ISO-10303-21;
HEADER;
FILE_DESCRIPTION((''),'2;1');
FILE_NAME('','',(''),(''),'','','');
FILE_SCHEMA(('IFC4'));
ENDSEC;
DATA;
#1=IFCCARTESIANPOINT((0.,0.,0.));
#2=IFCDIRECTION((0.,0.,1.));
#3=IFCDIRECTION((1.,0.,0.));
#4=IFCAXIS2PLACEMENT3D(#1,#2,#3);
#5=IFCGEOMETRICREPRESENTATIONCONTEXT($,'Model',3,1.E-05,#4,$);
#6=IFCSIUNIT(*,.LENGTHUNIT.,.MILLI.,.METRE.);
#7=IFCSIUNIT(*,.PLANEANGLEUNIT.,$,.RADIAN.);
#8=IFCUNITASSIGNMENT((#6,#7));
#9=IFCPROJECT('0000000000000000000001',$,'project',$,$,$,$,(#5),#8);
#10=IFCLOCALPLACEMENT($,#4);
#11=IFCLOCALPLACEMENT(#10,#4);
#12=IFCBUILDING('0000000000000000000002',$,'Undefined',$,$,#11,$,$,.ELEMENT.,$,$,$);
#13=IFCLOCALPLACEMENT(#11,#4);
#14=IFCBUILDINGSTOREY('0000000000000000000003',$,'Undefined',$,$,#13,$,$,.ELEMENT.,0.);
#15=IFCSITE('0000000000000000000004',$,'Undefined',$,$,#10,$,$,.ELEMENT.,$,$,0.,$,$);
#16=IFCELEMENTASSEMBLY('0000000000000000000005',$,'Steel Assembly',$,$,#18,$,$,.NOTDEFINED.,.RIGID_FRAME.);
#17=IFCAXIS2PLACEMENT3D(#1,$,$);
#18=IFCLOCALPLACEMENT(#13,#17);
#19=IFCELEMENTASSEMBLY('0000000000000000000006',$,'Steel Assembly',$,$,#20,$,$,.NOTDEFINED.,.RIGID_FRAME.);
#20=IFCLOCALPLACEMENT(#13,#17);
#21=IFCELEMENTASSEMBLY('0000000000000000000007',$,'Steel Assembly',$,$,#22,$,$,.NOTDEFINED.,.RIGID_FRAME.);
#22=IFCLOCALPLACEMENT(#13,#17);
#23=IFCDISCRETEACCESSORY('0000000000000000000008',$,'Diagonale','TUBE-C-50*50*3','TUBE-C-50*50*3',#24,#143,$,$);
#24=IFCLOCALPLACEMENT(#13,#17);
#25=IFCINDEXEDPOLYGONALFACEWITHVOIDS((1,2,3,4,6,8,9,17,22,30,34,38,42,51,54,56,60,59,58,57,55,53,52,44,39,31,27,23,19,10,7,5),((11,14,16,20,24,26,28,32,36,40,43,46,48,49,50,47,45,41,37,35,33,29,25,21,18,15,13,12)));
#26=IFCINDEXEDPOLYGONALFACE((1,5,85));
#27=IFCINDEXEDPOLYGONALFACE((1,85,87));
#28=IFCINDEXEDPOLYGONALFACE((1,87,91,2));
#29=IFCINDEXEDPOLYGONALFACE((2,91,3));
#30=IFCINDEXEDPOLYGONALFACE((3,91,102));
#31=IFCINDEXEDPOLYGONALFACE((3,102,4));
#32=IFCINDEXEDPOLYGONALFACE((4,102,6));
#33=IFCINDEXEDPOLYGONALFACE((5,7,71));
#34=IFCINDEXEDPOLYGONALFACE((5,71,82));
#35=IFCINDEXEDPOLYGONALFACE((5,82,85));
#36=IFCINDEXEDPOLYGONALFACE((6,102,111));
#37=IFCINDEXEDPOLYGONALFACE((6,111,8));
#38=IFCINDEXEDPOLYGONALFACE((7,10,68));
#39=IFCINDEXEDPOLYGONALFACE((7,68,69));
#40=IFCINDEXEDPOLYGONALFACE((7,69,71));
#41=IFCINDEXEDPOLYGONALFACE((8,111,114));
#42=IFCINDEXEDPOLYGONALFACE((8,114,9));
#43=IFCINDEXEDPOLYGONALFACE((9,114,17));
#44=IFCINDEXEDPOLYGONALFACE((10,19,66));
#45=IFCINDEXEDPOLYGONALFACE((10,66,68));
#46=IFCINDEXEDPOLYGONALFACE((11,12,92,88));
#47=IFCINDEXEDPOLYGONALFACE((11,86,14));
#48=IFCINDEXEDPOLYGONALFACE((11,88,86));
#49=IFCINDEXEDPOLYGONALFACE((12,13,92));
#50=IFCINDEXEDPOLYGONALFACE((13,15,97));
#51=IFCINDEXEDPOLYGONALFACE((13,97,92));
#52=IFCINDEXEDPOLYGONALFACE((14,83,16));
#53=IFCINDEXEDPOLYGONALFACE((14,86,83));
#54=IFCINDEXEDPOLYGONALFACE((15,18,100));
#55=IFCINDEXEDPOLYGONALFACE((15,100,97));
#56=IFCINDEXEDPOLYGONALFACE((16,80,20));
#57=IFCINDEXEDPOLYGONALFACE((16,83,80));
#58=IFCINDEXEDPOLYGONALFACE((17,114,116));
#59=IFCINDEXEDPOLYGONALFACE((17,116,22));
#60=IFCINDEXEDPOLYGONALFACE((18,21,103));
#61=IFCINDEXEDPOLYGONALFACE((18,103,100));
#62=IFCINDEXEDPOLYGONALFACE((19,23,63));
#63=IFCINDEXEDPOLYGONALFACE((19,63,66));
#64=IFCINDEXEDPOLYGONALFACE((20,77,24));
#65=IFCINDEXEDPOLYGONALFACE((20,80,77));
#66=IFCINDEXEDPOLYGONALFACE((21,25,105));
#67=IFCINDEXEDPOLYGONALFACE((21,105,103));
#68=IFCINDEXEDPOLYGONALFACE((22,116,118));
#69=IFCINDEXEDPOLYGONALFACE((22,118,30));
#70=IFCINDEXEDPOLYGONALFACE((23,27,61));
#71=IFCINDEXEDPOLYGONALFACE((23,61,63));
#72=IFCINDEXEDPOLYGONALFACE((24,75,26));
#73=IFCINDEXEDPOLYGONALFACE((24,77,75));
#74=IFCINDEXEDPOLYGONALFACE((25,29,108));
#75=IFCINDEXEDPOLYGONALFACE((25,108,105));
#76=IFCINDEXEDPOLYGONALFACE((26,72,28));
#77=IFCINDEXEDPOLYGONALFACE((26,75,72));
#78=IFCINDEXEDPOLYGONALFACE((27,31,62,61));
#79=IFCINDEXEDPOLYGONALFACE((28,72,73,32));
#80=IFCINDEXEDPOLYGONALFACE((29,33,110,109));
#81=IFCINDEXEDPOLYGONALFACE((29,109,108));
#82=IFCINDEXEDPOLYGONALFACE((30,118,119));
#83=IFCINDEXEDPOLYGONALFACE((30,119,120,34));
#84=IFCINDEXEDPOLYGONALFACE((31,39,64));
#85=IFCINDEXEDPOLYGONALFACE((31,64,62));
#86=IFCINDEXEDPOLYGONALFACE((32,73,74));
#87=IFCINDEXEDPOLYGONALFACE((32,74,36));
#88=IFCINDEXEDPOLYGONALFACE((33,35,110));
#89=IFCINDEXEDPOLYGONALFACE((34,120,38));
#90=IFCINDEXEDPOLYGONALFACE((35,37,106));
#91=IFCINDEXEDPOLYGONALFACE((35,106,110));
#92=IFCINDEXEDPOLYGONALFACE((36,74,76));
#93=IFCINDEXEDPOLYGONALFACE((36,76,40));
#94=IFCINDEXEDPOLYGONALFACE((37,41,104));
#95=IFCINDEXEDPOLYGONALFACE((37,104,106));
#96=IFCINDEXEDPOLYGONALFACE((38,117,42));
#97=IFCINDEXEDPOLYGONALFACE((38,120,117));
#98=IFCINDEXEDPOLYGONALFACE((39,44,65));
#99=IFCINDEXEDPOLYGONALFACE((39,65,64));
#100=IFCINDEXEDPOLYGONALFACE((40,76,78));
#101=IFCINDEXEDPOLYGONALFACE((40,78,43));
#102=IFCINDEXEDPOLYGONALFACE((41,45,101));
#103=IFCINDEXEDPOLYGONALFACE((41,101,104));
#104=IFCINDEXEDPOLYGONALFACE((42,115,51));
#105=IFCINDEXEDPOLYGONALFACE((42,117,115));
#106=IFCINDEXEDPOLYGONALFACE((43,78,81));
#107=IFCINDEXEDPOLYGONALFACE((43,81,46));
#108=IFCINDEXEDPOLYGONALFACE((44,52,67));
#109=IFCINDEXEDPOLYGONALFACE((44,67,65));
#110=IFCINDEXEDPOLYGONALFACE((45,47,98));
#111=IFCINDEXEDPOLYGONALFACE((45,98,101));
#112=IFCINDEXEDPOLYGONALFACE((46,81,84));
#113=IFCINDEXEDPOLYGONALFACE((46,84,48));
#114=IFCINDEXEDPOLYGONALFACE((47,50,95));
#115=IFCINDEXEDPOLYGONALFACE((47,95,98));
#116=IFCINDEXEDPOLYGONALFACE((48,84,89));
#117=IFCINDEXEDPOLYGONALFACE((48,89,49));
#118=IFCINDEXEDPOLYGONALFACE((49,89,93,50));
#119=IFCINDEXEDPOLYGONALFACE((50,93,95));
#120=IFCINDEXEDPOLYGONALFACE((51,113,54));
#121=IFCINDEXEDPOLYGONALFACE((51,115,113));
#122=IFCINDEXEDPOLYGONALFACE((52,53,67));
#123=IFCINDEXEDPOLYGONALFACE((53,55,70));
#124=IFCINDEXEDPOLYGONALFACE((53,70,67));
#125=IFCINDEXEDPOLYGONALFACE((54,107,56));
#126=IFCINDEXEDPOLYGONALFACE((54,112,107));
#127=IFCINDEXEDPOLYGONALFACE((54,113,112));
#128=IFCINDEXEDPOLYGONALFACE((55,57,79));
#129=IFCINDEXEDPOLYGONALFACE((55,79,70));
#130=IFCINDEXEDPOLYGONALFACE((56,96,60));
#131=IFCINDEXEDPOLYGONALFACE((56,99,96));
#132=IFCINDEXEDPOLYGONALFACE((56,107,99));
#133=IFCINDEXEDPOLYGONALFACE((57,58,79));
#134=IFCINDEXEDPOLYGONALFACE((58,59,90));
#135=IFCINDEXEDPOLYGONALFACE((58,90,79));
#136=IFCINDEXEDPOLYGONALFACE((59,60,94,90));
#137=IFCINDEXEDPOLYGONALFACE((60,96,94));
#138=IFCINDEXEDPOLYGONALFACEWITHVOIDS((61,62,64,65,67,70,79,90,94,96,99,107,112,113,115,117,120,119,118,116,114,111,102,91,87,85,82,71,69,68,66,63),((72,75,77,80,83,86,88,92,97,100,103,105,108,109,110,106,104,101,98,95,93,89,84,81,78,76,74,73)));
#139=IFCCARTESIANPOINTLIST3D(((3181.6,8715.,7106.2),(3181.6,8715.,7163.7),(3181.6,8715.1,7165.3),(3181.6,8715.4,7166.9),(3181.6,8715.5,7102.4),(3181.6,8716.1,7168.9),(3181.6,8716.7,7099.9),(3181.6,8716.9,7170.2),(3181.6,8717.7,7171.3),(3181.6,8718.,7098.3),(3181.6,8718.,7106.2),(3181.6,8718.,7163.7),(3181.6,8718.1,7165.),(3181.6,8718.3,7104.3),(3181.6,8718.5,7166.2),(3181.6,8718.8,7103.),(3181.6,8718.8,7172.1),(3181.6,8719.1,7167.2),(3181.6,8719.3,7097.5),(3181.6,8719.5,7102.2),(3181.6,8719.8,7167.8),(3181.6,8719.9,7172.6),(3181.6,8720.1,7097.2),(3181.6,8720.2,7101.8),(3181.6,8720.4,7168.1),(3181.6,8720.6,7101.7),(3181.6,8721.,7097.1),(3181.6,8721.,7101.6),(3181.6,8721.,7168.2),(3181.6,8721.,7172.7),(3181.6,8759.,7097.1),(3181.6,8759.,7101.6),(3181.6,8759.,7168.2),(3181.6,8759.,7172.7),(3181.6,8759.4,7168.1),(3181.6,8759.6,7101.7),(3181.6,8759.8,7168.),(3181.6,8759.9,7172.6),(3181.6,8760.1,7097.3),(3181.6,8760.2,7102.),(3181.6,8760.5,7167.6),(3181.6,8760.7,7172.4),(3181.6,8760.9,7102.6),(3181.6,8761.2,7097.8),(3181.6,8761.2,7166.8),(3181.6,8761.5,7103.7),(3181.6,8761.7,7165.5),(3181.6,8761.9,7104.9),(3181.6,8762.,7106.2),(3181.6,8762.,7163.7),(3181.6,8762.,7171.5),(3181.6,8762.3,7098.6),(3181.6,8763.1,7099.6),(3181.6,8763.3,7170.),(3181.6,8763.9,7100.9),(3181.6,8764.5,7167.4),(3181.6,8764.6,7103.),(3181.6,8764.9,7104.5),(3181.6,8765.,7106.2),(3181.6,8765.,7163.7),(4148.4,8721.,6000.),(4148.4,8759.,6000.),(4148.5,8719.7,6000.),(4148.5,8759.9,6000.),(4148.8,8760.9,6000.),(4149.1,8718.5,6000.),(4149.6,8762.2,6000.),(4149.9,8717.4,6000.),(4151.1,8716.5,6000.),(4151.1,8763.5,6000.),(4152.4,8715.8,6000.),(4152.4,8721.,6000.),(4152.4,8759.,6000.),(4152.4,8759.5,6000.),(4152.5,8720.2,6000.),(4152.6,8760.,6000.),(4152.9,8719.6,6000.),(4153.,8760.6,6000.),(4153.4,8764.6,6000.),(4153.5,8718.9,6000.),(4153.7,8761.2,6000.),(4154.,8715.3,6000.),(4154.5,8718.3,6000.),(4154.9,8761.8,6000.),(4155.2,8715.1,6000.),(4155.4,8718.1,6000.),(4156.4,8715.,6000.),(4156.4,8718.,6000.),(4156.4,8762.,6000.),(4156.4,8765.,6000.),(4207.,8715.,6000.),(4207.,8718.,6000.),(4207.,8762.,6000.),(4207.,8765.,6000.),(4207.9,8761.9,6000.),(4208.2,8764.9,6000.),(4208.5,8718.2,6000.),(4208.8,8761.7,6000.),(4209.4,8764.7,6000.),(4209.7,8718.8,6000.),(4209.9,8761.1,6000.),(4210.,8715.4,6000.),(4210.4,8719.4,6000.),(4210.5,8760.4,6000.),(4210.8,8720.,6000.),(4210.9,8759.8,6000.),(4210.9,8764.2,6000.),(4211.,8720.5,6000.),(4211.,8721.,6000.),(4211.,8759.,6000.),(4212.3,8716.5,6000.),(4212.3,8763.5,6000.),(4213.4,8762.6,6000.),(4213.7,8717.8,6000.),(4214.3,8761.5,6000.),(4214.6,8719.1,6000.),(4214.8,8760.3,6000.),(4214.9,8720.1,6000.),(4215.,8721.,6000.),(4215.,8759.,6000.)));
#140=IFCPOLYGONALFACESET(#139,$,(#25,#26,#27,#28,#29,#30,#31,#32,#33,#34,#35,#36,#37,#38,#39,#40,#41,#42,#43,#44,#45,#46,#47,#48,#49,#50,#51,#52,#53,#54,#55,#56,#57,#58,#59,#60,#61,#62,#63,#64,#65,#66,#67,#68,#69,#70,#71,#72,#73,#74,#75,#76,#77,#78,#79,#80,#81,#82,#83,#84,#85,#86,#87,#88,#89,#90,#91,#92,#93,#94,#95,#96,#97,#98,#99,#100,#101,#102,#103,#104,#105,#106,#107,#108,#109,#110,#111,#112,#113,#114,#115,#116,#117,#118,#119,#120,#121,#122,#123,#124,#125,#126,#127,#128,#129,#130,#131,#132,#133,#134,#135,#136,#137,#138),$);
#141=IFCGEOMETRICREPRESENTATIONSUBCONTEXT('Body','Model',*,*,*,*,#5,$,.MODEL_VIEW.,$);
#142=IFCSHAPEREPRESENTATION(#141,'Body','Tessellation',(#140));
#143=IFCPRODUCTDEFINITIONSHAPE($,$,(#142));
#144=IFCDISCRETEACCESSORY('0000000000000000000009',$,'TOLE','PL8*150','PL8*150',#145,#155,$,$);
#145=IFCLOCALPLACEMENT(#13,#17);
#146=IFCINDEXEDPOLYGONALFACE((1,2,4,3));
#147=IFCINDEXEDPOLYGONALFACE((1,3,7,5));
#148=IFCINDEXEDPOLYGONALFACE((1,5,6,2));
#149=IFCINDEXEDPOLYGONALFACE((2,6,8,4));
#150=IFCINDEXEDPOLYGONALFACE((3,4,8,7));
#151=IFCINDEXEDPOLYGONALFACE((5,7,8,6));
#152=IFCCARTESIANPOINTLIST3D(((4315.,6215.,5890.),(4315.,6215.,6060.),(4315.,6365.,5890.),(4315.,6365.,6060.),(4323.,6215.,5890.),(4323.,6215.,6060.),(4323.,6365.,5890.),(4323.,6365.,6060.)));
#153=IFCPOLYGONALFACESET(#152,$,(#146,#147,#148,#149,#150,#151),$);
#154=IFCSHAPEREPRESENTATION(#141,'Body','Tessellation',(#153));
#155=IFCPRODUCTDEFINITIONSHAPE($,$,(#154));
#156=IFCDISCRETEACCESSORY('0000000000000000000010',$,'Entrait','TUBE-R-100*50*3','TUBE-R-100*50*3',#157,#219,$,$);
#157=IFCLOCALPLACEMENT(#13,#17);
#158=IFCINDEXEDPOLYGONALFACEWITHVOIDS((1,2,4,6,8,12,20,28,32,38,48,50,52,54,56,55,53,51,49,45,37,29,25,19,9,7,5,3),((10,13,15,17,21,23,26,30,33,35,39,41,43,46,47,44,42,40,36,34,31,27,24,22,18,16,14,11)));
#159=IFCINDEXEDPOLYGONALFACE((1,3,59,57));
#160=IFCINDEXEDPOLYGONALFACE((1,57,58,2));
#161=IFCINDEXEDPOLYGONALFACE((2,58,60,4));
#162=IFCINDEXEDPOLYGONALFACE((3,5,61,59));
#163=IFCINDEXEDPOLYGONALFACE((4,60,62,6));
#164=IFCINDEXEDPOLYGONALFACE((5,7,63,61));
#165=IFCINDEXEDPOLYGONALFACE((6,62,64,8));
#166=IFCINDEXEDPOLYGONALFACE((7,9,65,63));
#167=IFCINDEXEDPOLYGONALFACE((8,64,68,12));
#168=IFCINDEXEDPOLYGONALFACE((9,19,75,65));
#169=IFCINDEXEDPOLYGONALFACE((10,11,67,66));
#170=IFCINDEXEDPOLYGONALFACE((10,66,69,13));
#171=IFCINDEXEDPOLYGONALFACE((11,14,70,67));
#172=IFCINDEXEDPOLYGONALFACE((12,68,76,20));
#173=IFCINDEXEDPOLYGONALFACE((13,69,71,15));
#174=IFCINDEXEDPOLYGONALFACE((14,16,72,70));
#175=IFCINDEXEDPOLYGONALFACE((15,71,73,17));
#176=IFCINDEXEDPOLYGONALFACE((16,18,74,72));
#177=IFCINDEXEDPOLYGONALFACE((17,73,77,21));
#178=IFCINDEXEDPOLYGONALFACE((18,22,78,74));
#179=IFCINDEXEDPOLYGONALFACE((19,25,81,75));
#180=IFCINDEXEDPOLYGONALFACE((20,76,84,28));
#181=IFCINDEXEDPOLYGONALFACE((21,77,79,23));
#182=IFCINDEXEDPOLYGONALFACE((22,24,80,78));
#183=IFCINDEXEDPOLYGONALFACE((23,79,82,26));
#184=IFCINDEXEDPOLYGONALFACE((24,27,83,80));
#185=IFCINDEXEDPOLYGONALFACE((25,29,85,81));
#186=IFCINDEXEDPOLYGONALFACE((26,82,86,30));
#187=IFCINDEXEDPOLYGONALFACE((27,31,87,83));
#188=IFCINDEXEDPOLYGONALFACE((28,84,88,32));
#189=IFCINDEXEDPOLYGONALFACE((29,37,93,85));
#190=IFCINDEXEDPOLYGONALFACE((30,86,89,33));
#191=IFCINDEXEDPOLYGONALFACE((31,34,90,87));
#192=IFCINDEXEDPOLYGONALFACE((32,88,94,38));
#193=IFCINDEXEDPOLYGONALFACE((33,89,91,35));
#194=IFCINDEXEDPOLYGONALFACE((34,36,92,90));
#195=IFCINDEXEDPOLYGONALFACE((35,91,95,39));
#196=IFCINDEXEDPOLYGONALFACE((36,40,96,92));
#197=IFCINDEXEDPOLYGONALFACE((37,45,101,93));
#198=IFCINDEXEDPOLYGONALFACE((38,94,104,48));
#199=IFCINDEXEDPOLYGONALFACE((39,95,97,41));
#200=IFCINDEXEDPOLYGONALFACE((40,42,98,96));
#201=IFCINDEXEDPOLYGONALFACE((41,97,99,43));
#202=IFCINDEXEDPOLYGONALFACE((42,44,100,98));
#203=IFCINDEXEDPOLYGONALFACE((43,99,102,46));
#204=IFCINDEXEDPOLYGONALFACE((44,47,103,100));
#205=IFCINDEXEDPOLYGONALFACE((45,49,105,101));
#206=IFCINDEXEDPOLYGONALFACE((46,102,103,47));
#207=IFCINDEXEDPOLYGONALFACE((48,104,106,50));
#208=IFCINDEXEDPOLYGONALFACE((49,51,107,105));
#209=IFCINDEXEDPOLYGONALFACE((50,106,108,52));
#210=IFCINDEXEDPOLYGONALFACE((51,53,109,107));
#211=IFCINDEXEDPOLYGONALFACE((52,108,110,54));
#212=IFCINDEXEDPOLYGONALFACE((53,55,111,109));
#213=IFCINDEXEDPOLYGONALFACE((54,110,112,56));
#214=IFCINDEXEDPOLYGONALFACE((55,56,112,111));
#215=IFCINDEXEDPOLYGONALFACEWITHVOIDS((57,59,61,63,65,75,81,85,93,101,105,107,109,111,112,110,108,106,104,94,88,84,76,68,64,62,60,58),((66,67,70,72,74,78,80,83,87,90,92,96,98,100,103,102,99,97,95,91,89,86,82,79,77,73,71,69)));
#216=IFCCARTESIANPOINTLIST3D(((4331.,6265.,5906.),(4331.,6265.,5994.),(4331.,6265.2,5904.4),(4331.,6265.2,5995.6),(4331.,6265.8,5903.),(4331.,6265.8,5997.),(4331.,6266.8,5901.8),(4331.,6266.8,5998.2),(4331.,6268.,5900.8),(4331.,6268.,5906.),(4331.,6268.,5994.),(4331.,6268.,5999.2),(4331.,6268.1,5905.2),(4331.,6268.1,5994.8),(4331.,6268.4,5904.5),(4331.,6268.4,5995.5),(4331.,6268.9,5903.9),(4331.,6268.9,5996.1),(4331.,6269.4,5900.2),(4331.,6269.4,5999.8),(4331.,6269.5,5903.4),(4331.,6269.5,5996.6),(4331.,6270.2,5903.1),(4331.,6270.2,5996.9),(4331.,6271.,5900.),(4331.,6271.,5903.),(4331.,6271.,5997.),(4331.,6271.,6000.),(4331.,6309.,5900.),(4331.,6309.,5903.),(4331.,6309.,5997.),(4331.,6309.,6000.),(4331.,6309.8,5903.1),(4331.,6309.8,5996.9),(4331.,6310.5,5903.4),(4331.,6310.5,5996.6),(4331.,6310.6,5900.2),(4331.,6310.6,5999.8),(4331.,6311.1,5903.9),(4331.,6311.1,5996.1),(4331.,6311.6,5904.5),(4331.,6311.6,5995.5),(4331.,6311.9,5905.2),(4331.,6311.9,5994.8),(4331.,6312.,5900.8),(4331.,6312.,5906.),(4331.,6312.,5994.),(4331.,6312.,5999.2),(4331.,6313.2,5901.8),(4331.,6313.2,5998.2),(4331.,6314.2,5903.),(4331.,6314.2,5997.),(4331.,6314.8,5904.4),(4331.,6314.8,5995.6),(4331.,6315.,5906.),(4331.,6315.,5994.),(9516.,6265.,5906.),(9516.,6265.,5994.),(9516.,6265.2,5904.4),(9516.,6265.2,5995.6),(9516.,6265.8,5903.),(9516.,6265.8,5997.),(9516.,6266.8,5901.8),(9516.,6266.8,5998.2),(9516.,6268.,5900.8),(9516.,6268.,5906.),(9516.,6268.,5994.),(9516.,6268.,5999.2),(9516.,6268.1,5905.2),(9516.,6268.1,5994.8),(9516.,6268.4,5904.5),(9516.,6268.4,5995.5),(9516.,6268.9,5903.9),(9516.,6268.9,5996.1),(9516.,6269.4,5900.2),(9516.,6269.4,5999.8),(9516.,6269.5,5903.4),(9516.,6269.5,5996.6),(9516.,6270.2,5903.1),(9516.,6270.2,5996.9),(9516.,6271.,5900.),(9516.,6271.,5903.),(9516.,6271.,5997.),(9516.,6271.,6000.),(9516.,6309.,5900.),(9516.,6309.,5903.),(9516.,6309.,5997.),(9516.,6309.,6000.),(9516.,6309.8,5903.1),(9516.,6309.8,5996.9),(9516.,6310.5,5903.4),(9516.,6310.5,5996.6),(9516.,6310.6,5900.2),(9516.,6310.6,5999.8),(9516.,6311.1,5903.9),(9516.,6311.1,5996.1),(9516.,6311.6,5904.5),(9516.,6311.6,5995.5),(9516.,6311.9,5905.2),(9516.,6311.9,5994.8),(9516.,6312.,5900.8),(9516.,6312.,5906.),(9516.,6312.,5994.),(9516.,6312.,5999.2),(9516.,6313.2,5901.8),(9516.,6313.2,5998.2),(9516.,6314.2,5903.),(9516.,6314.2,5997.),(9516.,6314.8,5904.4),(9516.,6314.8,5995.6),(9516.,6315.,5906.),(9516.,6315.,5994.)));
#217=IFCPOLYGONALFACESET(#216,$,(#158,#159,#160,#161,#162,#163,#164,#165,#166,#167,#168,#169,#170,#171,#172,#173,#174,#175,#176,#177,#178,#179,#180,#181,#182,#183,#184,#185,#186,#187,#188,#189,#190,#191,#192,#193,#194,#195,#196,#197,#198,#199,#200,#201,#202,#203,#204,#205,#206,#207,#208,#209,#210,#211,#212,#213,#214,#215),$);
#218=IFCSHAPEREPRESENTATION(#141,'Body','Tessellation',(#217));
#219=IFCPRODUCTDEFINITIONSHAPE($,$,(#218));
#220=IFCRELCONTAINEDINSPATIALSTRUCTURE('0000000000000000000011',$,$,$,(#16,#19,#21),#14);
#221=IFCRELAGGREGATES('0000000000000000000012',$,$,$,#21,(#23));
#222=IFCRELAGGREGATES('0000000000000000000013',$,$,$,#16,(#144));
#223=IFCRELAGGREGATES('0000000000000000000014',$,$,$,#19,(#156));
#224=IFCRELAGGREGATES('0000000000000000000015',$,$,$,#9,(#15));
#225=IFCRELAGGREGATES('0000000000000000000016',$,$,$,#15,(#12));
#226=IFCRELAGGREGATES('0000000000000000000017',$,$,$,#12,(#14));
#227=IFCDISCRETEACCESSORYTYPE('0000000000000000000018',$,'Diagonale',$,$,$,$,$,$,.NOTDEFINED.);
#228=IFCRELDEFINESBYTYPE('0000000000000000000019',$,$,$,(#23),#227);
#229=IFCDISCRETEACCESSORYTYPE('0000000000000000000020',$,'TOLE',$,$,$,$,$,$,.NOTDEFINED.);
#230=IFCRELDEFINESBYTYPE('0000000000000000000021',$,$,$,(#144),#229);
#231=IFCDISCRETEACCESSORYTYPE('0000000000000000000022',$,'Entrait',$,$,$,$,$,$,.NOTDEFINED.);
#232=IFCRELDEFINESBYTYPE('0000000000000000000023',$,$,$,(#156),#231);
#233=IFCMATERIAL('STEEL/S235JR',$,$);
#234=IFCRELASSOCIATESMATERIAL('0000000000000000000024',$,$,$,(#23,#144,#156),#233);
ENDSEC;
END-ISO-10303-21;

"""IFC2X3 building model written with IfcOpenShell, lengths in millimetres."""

from ifc_helpers import new_model, si_unit, frame, origin_with_axes, origin_2d_with_axis, place, context, subcontext, project, spatial, polyline, hollow_rectangle, outline, extrude, clip, halfspace, material, type_object, element, aggregate, save


model = new_model("IFC2X3")

# Units and contexts
model_context = context("Model", 3, precision=1e-05, world=origin_with_axes())
body_context = subcontext(model_context, "Body", "Model", "MODEL_VIEW")
ifc_project = project(units=[si_unit("LENGTHUNIT", "METRE", prefix="MILLI"), si_unit("PLANEANGLEUNIT", "RADIAN")], contexts=[model_context])

# Site, building, storey
site_placement = place(None, origin_with_axes())
site = spatial("IfcSite", under=ifc_project, at=site_placement, Name="Undefined", CompositionType="ELEMENT", RefElevation=0.0)
building_placement = place(site_placement, origin_with_axes())
building = spatial("IfcBuilding", under=site, at=building_placement, Name="Undefined", CompositionType="ELEMENT")
storey_placement = place(building_placement, origin_with_axes())
storey = spatial("IfcBuildingStorey", under=building, at=storey_placement, Name="Undefined", CompositionType="ELEMENT", Elevation=0.0)

# Shared definitions
ifc_material_1 = material(Name="STEEL/S235JR")

# Element assemblies
assembly_1_placement = place(storey_placement, origin_with_axes())
assembly_1 = element("IfcElementAssembly", 1, at=assembly_1_placement, inside=storey, Name="Steel Assembly", AssemblyPlace="NOTDEFINED", PredefinedType="RIGID_FRAME")
assembly_2_placement = place(storey_placement, origin_with_axes())
assembly_2 = element("IfcElementAssembly", 2, at=assembly_2_placement, inside=storey, Name="Steel Assembly", AssemblyPlace="NOTDEFINED", PredefinedType="RIGID_FRAME")

# Element assembly
assembly_3_placement = place(storey_placement, origin_with_axes())
assembly_3 = element("IfcElementAssembly", 3, at=assembly_3_placement, inside=storey, Name="Steel Assembly", AssemblyPlace="NOTDEFINED", PredefinedType="RIGID_FRAME")

# Discrete accessory
discrete_accessory_type_1 = type_object("IfcDiscreteAccessoryType", Name="Diagonale")
discrete_accessory_1_placement = place(assembly_3_placement, frame((4196.2, 8740.0, 5983.5), z_axis=(0.75026, 0.0, 0.661143), x_axis=(-0.661143, 0.0, 0.75026)))
discrete_accessory_1 = element("IfcDiscreteAccessory", 4, at=discrete_accessory_1_placement, type_object=discrete_accessory_type_1, material=ifc_material_1, Name="Diagonale", Description="TUBE-C-50*50*3", ObjectType="TUBE-C-50*50*3", context=body_context, shape_type="Clipping", body=[
    clip(clip(extrude(hollow_rectangle(XDim=50.0, YDim=50.0, WallThickness=3.0, InnerFilletRadius=3.0, OuterFilletRadius=6.0, at=origin_2d_with_axis()), frame((1797.9, 0.0, 0.0), z_axis=(-1.0, 0.0, 0.0), x_axis=(0.0, -1.0, 0.0)), (0.0, 0.0, 1.0), 1826.7), halfspace(frame((1590.7, 0.0, 49.4), z_axis=(-0.661143, 0.0, 0.75026), x_axis=(-0.75026, 0.0, -0.661143)), True)), halfspace(frame((69.0, 0.0, -53.3), z_axis=(0.75026, 0.0, 0.661143), x_axis=(-0.661143, 0.0, 0.75026)), True)),
])
aggregate(assembly_3, [discrete_accessory_1])

# Discrete accessories
discrete_accessory_type_2 = type_object("IfcDiscreteAccessoryType", Name="TOLE")
discrete_accessory_2_placement = place(assembly_1_placement, frame((4319.0, 6290.0, 5890.0), z_axis=(1.0, 0.0, 0.0), x_axis=(0.0, 0.0, 1.0)))
discrete_accessory_2 = element("IfcDiscreteAccessory", 5, at=discrete_accessory_2_placement, type_object=discrete_accessory_type_2, material=ifc_material_1, Name="TOLE", Description="PL8*150", ObjectType="PL8*150", context=body_context, shape_type="SweptSolid", body=[
    extrude(outline(polyline([(170.0, 75.0), (170.0, -75.0), (0.0, -75.0), (0.0, 75.0), (170.0, 75.0)])), frame((0.0, 0.0, -4.0), z_axis=(0.0, 0.0, 1.0), x_axis=(1.0, 0.0, 0.0)), (0.0, 0.0, 1.0), 8.0),
])
aggregate(assembly_1, [discrete_accessory_2])
discrete_accessory_type_3 = type_object("IfcDiscreteAccessoryType", Name="Entrait")
discrete_accessory_3_placement = place(assembly_2_placement, frame((4315.0, 6290.0, 5950.0), z_axis=(0.0, 0.0, 1.0), x_axis=(1.0, 0.0, 0.0)))
discrete_accessory_3 = element("IfcDiscreteAccessory", 6, at=discrete_accessory_3_placement, type_object=discrete_accessory_type_3, material=ifc_material_1, Name="Entrait", Description="TUBE-R-100*50*3", ObjectType="TUBE-R-100*50*3", context=body_context, shape_type="SweptSolid", body=[
    extrude(hollow_rectangle(XDim=50.0, YDim=100.0, WallThickness=3.0, InnerFilletRadius=3.0, OuterFilletRadius=6.0, at=origin_2d_with_axis()), frame((5201.0, 0.0, 0.0), z_axis=(-1.0, 0.0, 0.0), x_axis=(0.0, -1.0, 0.0)), (0.0, 0.0, 1.0), 5185.0),
])
aggregate(assembly_2, [discrete_accessory_3])

save(model, "model.ifc")
